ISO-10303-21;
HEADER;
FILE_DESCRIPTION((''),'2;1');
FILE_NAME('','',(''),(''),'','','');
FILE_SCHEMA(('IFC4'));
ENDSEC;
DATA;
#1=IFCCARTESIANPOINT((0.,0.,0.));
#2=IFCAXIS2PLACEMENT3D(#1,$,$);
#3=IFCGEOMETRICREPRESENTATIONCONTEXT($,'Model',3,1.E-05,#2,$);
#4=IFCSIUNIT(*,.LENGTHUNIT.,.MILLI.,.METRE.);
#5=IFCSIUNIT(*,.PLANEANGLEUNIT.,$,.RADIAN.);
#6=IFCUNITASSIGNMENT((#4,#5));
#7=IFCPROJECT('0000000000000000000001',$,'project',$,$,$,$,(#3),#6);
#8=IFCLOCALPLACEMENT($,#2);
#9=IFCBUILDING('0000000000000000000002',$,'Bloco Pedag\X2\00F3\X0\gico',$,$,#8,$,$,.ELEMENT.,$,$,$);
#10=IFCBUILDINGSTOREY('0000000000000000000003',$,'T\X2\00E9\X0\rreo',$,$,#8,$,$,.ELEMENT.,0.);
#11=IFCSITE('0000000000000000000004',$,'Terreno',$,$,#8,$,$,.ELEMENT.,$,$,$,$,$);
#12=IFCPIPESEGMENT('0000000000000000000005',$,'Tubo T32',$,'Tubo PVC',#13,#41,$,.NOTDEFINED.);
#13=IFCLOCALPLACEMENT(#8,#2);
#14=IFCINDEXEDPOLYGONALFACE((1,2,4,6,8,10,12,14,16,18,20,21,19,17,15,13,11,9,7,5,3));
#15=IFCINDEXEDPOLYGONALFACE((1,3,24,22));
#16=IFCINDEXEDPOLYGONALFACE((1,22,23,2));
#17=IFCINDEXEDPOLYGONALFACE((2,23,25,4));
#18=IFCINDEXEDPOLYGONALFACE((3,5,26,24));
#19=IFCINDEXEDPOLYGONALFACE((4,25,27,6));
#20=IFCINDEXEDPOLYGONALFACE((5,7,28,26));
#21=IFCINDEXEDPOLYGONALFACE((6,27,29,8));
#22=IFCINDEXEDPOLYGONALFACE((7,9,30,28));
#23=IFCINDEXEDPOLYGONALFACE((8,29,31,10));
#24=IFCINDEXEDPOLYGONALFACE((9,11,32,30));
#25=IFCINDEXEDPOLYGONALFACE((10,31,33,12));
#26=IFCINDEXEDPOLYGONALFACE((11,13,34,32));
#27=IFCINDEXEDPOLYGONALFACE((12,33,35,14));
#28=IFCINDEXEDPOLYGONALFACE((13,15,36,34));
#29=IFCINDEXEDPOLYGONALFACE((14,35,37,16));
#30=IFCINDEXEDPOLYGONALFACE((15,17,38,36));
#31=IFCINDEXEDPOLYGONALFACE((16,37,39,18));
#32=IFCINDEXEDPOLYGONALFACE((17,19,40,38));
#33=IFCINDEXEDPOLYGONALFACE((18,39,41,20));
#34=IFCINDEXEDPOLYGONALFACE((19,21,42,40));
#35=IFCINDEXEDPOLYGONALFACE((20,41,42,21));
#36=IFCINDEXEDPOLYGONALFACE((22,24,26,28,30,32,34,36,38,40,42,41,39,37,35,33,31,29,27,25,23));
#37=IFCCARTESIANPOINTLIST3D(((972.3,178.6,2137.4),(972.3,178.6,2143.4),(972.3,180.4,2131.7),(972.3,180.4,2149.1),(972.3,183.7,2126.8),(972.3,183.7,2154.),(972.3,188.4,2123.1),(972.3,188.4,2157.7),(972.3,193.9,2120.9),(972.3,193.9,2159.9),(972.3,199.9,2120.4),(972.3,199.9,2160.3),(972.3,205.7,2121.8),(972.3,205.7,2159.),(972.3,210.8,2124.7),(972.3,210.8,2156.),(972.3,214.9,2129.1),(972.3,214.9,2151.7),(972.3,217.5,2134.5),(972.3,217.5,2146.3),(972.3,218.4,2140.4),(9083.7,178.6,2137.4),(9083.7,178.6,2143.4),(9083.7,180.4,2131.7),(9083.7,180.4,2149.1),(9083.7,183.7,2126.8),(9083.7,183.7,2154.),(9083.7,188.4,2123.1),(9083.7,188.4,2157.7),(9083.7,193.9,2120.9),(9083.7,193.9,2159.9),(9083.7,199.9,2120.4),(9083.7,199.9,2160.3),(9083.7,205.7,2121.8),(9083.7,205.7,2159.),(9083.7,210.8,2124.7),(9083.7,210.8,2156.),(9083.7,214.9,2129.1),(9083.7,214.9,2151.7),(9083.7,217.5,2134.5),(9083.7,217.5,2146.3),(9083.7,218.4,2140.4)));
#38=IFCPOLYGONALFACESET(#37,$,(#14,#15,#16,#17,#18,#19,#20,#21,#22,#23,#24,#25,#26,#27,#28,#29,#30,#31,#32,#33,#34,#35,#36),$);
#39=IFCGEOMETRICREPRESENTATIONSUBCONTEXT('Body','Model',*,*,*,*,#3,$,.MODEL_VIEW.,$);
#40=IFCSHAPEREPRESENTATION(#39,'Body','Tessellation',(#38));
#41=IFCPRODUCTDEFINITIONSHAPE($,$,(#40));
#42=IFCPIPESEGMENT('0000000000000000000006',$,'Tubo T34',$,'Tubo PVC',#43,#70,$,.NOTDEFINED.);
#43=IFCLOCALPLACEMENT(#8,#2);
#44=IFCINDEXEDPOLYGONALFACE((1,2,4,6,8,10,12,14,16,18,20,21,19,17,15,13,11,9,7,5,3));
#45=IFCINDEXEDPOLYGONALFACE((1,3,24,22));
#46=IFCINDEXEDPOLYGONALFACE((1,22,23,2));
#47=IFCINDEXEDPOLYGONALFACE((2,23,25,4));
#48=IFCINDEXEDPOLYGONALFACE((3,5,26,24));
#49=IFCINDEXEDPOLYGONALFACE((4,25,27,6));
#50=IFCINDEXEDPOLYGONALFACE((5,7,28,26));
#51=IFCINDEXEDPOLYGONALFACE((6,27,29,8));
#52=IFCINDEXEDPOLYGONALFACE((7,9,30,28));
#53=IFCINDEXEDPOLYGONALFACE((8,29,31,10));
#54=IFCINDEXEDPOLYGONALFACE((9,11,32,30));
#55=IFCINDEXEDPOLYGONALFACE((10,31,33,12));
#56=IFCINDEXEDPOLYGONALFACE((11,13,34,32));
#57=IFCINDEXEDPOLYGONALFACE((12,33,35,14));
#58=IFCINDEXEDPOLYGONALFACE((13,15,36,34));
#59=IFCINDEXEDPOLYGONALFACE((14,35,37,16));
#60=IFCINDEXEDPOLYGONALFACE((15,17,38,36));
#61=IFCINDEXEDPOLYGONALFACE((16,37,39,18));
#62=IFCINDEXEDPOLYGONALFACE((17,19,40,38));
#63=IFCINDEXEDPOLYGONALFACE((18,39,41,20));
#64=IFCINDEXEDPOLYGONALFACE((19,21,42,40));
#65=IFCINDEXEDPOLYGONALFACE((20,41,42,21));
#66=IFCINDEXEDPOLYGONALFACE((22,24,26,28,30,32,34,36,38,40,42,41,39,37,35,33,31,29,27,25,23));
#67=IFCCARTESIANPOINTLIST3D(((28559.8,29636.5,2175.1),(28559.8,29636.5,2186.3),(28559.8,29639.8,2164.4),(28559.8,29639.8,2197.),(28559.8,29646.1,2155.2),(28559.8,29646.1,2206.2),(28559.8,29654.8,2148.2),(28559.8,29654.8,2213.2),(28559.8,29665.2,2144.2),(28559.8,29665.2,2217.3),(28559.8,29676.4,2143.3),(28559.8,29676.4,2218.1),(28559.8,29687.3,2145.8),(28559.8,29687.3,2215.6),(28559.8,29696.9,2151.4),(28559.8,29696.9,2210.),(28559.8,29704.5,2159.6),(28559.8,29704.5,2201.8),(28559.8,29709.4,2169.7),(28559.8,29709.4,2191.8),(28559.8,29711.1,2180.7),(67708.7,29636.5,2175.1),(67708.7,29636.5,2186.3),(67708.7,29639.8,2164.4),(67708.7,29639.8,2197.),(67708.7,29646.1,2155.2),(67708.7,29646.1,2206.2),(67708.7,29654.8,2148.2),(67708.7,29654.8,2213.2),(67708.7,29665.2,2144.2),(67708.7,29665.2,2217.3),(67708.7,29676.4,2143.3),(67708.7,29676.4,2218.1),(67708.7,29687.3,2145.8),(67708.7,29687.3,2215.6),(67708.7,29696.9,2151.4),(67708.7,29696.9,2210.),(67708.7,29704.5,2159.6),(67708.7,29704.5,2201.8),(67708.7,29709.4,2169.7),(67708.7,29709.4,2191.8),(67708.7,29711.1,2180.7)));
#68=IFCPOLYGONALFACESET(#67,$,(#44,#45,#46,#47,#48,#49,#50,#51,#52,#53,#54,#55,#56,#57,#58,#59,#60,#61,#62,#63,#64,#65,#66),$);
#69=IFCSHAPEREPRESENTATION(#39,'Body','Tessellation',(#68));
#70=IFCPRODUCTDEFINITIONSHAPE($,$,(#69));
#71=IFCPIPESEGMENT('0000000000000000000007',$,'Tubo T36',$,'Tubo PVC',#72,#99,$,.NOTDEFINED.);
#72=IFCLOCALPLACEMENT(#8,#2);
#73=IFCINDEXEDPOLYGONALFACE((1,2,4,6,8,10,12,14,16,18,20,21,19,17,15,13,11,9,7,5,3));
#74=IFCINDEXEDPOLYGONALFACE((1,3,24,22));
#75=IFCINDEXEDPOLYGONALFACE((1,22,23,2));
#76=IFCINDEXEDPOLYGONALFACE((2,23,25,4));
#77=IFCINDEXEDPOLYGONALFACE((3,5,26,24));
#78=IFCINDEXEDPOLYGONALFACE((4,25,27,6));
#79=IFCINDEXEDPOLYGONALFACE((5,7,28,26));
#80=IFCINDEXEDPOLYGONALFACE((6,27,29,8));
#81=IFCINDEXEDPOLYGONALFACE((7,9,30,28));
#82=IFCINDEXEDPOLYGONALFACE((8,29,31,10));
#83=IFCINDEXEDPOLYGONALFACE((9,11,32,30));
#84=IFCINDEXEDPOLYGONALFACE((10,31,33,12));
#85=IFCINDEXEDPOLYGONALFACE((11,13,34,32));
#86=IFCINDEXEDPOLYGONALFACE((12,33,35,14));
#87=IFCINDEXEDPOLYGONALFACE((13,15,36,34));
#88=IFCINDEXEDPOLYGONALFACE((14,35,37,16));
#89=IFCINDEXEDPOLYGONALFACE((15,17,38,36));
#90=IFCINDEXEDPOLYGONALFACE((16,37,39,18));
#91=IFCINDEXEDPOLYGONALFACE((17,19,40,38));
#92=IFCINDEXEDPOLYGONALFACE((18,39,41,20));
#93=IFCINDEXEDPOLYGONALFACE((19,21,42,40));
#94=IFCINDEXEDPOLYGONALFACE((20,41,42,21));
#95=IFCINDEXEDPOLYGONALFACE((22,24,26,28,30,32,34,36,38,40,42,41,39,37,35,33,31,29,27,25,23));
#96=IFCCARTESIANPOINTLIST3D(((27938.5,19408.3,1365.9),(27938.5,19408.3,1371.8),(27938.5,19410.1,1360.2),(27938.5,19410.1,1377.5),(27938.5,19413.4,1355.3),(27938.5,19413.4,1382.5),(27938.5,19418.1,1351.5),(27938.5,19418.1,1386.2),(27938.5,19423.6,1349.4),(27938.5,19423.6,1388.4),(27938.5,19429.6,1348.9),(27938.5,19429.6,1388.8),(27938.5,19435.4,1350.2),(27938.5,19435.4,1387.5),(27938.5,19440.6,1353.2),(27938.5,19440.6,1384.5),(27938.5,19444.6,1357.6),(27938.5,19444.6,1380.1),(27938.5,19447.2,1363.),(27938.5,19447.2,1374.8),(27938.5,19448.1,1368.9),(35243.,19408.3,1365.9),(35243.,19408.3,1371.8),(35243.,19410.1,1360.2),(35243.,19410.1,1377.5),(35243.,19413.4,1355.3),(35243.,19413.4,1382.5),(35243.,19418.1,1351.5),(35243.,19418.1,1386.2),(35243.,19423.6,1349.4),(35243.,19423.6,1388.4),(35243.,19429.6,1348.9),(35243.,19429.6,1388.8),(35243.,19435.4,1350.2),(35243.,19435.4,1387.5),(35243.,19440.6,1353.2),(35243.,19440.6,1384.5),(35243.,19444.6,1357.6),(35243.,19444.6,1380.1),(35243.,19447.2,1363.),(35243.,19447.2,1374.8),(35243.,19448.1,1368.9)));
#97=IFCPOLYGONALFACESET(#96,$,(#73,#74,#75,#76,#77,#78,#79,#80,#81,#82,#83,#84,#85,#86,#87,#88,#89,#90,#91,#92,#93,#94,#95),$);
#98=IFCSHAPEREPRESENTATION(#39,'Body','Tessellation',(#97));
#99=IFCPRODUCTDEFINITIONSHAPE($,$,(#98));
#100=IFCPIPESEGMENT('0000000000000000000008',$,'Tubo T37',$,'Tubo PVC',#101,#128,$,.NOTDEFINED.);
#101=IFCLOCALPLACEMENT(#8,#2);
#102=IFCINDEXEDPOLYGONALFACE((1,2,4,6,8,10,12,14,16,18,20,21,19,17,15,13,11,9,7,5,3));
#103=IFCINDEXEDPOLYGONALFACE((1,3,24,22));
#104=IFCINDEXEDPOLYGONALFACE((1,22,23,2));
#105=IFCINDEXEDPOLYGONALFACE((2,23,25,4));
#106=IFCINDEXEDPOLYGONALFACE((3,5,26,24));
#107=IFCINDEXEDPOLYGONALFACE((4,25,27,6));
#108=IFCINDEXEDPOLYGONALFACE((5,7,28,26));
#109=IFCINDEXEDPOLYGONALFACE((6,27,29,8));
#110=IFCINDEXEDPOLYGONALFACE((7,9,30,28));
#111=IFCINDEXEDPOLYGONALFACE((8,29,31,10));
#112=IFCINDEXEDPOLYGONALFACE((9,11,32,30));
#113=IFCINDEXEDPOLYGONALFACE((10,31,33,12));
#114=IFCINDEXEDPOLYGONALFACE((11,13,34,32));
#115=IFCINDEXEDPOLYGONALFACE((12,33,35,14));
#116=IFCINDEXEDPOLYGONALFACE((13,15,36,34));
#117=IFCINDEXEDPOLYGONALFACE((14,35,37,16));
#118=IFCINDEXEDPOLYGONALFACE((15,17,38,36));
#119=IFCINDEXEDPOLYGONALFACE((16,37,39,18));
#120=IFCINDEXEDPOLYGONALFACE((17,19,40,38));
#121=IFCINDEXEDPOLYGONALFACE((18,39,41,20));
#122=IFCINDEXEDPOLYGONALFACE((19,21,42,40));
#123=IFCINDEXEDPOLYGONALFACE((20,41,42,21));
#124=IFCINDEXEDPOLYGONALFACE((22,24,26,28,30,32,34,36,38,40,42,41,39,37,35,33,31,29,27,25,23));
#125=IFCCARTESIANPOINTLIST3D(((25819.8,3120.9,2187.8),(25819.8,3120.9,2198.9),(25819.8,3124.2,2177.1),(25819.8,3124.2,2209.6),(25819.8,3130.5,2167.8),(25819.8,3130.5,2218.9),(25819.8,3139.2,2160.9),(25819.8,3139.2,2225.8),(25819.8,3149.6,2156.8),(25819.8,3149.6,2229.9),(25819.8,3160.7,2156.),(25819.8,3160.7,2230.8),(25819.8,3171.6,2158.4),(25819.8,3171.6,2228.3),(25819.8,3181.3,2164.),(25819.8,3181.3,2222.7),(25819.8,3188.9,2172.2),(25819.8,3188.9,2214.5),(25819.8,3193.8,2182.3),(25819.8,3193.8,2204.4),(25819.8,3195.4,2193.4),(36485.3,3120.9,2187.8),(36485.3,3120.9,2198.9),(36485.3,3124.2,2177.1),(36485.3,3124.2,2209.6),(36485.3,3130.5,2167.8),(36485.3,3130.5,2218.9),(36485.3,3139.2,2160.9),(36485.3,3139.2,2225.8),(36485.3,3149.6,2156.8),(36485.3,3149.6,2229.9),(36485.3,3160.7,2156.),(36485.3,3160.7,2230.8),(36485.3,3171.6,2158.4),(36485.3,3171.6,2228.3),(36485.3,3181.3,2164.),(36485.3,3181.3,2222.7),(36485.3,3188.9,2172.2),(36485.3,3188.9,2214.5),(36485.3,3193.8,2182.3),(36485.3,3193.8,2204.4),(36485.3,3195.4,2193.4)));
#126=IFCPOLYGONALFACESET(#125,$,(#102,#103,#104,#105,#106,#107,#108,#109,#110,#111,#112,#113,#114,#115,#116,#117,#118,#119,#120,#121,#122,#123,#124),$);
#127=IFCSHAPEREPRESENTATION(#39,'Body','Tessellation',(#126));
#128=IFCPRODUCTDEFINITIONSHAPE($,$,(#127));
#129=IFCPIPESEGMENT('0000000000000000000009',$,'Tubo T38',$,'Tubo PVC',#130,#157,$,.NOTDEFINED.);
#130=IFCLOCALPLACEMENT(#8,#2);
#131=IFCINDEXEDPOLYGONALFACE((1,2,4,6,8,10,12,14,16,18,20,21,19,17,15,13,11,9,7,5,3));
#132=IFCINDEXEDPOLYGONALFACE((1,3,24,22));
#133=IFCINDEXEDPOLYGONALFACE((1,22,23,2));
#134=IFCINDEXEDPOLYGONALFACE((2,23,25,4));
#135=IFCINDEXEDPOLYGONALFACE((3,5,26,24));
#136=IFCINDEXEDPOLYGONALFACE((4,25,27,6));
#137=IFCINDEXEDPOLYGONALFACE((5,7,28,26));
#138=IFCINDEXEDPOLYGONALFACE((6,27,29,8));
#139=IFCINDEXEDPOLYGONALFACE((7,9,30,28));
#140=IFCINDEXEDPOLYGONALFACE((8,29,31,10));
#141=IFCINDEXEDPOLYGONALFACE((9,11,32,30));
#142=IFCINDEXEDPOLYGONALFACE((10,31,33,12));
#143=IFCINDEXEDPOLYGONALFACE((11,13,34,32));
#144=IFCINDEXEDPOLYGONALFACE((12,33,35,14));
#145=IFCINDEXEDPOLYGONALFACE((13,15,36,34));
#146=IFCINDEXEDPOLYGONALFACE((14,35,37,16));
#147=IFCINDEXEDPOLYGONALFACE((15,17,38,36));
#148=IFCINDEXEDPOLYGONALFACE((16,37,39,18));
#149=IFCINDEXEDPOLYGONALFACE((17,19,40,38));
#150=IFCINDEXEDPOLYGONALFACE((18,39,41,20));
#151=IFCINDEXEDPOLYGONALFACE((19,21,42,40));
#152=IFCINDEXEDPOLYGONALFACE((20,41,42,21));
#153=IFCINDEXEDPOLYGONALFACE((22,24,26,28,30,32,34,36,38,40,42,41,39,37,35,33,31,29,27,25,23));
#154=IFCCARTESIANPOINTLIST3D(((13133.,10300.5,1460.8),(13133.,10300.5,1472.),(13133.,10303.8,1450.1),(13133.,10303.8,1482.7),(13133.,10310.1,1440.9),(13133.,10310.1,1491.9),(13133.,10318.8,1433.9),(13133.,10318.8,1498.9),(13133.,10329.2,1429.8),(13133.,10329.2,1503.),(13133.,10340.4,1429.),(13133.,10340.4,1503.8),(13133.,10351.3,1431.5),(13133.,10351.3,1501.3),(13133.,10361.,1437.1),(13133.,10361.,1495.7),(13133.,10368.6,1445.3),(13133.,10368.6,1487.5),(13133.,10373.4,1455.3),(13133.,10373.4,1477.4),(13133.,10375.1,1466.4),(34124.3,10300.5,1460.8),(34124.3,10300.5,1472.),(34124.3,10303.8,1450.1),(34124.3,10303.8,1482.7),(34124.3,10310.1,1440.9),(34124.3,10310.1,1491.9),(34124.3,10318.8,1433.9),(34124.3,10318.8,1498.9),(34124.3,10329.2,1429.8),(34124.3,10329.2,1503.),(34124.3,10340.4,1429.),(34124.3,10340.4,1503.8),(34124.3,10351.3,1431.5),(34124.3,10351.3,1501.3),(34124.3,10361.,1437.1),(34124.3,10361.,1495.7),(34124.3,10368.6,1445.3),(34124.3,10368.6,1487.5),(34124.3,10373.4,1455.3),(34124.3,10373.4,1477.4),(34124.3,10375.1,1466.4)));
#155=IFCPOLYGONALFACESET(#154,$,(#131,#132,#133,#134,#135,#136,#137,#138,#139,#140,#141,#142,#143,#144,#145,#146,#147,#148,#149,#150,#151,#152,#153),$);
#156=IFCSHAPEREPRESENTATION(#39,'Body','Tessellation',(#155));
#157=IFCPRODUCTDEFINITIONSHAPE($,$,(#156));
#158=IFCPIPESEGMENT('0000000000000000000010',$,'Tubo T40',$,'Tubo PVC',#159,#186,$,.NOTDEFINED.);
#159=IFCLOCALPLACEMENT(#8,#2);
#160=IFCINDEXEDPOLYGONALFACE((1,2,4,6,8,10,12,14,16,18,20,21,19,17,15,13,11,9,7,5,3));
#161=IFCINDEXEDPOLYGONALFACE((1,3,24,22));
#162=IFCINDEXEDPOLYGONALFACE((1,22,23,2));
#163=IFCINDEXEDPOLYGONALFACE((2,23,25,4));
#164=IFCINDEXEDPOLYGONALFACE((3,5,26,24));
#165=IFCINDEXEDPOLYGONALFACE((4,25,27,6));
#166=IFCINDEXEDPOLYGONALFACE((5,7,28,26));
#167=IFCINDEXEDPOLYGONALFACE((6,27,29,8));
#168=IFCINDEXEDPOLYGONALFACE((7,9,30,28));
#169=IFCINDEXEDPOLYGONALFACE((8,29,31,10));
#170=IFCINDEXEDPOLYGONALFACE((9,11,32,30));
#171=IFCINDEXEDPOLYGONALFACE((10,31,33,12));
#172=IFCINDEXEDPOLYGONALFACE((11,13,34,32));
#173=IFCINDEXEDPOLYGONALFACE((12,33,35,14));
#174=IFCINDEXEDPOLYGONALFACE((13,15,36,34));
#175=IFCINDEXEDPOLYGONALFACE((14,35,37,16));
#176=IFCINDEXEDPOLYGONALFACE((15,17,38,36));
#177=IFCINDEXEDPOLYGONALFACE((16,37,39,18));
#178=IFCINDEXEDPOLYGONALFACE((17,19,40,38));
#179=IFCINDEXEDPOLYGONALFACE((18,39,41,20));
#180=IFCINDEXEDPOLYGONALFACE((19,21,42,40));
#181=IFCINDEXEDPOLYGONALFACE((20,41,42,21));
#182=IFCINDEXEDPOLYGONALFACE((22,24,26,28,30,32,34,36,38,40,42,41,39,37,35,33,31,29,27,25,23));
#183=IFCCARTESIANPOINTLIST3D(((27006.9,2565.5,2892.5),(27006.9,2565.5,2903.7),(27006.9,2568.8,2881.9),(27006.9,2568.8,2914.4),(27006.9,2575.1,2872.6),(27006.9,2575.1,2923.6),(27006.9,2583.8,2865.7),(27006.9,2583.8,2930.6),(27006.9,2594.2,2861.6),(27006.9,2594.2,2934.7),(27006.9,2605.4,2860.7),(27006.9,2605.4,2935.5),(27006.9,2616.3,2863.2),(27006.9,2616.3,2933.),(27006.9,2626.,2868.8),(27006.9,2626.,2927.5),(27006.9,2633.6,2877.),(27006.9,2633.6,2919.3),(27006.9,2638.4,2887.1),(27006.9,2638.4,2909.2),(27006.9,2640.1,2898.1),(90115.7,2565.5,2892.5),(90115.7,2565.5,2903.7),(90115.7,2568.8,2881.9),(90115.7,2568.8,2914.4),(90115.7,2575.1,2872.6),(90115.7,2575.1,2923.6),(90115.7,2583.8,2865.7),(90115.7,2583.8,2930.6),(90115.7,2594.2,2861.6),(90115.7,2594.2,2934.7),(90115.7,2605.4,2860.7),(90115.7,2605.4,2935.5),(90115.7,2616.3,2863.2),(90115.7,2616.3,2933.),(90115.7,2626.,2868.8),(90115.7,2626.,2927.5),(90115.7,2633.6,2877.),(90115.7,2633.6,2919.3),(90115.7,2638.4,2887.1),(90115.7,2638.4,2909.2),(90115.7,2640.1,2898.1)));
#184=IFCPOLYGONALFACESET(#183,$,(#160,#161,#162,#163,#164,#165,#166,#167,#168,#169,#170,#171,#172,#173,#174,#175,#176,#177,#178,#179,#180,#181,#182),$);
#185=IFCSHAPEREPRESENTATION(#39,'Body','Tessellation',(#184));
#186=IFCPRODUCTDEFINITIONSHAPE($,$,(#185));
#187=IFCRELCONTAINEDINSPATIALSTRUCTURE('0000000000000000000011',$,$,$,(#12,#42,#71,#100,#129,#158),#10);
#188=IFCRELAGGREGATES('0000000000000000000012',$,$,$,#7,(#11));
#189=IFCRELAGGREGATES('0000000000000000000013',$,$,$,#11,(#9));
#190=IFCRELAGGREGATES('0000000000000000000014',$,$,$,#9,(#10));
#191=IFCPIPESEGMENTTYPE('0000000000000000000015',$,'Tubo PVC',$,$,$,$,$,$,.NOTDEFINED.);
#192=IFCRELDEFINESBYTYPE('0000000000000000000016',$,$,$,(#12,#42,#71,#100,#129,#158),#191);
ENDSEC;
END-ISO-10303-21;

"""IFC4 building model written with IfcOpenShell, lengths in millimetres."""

from ifc_helpers import new_model, si_unit, frame, origin, origin_2d, place, context, subcontext, project, spatial, circle, extrude, type_object, element, save


model = new_model("IFC4")

# Units and contexts
model_context = context("Model", 3, precision=1e-05, world=origin())
body_context = subcontext(model_context, "Body", "Model", "MODEL_VIEW")
ifc_project = project(units=[si_unit("LENGTHUNIT", "METRE", prefix="MILLI"), si_unit("PLANEANGLEUNIT", "RADIAN")], contexts=[model_context])

# Site, building, storey
placement = place(None, origin())
site = spatial("IfcSite", under=ifc_project, at=placement, Name="Terreno", CompositionType="ELEMENT")
building = spatial("IfcBuilding", under=site, at=placement, Name="Bloco Pedagógico", CompositionType="ELEMENT")
storey = spatial("IfcBuildingStorey", under=building, at=placement, Name="Térreo", CompositionType="ELEMENT", Elevation=0.0)

# Pipe segments
pipe_segment_type = type_object("IfcPipeSegmentType", Name="Tubo PVC", PredefinedType="NOTDEFINED")
pipe_segment_1_placement = place(None, frame((972.3, 198.4, 2140.4), z_axis=(1.0, 0.0, 0.0), x_axis=(0.0, 1.0, 0.0)))
element("IfcPipeSegment", 1, at=pipe_segment_1_placement, inside=storey, type_object=pipe_segment_type, Name="Tubo T32", ObjectType="Tubo PVC", PredefinedType="NOTDEFINED", context=body_context, shape_type="SweptSolid", body=[
    extrude(circle(Radius=20.0, at=origin_2d()), None, (0.0, 0.0, 1.0), 8111.4),
])
pipe_segment_2_placement = place(None, frame((28559.8, 29673.6, 2180.7), z_axis=(1.0, 0.0, 0.0), x_axis=(0.0, 1.0, 0.0)))
element("IfcPipeSegment", 2, at=pipe_segment_2_placement, inside=storey, type_object=pipe_segment_type, Name="Tubo T34", ObjectType="Tubo PVC", PredefinedType="NOTDEFINED", context=body_context, shape_type="SweptSolid", body=[
    extrude(circle(Radius=37.5, at=origin_2d()), None, (0.0, 0.0, 1.0), 39148.9),
])
pipe_segment_3_placement = place(None, frame((27938.5, 19428.1, 1368.9), z_axis=(1.0, 0.0, 0.0), x_axis=(0.0, 1.0, 0.0)))
element("IfcPipeSegment", 3, at=pipe_segment_3_placement, inside=storey, type_object=pipe_segment_type, Name="Tubo T36", ObjectType="Tubo PVC", PredefinedType="NOTDEFINED", context=body_context, shape_type="SweptSolid", body=[
    extrude(circle(Radius=20.0, at=origin_2d()), None, (0.0, 0.0, 1.0), 7304.4),
])
pipe_segment_4_placement = place(None, frame((25819.8, 3157.9, 2193.4), z_axis=(1.0, 0.0, 0.0), x_axis=(0.0, 1.0, 0.0)))
element("IfcPipeSegment", 4, at=pipe_segment_4_placement, inside=storey, type_object=pipe_segment_type, Name="Tubo T37", ObjectType="Tubo PVC", PredefinedType="NOTDEFINED", context=body_context, shape_type="SweptSolid", body=[
    extrude(circle(Radius=37.5, at=origin_2d()), None, (0.0, 0.0, 1.0), 10665.4),
])
pipe_segment_5_placement = place(None, frame((13133.0, 10337.6, 1466.4), z_axis=(1.0, 0.0, 0.0), x_axis=(0.0, 1.0, 0.0)))
element("IfcPipeSegment", 5, at=pipe_segment_5_placement, inside=storey, type_object=pipe_segment_type, Name="Tubo T38", ObjectType="Tubo PVC", PredefinedType="NOTDEFINED", context=body_context, shape_type="SweptSolid", body=[
    extrude(circle(Radius=37.5, at=origin_2d()), None, (0.0, 0.0, 1.0), 20991.3),
])
pipe_segment_6_placement = place(None, frame((27006.9, 2602.6, 2898.1), z_axis=(1.0, 0.0, 0.0), x_axis=(0.0, 1.0, 0.0)))
element("IfcPipeSegment", 6, at=pipe_segment_6_placement, inside=storey, type_object=pipe_segment_type, Name="Tubo T40", ObjectType="Tubo PVC", PredefinedType="NOTDEFINED", context=body_context, shape_type="SweptSolid", body=[
    extrude(circle(Radius=37.5, at=origin_2d()), None, (0.0, 0.0, 1.0), 63108.8),
])

save(model, "model.ifc")
